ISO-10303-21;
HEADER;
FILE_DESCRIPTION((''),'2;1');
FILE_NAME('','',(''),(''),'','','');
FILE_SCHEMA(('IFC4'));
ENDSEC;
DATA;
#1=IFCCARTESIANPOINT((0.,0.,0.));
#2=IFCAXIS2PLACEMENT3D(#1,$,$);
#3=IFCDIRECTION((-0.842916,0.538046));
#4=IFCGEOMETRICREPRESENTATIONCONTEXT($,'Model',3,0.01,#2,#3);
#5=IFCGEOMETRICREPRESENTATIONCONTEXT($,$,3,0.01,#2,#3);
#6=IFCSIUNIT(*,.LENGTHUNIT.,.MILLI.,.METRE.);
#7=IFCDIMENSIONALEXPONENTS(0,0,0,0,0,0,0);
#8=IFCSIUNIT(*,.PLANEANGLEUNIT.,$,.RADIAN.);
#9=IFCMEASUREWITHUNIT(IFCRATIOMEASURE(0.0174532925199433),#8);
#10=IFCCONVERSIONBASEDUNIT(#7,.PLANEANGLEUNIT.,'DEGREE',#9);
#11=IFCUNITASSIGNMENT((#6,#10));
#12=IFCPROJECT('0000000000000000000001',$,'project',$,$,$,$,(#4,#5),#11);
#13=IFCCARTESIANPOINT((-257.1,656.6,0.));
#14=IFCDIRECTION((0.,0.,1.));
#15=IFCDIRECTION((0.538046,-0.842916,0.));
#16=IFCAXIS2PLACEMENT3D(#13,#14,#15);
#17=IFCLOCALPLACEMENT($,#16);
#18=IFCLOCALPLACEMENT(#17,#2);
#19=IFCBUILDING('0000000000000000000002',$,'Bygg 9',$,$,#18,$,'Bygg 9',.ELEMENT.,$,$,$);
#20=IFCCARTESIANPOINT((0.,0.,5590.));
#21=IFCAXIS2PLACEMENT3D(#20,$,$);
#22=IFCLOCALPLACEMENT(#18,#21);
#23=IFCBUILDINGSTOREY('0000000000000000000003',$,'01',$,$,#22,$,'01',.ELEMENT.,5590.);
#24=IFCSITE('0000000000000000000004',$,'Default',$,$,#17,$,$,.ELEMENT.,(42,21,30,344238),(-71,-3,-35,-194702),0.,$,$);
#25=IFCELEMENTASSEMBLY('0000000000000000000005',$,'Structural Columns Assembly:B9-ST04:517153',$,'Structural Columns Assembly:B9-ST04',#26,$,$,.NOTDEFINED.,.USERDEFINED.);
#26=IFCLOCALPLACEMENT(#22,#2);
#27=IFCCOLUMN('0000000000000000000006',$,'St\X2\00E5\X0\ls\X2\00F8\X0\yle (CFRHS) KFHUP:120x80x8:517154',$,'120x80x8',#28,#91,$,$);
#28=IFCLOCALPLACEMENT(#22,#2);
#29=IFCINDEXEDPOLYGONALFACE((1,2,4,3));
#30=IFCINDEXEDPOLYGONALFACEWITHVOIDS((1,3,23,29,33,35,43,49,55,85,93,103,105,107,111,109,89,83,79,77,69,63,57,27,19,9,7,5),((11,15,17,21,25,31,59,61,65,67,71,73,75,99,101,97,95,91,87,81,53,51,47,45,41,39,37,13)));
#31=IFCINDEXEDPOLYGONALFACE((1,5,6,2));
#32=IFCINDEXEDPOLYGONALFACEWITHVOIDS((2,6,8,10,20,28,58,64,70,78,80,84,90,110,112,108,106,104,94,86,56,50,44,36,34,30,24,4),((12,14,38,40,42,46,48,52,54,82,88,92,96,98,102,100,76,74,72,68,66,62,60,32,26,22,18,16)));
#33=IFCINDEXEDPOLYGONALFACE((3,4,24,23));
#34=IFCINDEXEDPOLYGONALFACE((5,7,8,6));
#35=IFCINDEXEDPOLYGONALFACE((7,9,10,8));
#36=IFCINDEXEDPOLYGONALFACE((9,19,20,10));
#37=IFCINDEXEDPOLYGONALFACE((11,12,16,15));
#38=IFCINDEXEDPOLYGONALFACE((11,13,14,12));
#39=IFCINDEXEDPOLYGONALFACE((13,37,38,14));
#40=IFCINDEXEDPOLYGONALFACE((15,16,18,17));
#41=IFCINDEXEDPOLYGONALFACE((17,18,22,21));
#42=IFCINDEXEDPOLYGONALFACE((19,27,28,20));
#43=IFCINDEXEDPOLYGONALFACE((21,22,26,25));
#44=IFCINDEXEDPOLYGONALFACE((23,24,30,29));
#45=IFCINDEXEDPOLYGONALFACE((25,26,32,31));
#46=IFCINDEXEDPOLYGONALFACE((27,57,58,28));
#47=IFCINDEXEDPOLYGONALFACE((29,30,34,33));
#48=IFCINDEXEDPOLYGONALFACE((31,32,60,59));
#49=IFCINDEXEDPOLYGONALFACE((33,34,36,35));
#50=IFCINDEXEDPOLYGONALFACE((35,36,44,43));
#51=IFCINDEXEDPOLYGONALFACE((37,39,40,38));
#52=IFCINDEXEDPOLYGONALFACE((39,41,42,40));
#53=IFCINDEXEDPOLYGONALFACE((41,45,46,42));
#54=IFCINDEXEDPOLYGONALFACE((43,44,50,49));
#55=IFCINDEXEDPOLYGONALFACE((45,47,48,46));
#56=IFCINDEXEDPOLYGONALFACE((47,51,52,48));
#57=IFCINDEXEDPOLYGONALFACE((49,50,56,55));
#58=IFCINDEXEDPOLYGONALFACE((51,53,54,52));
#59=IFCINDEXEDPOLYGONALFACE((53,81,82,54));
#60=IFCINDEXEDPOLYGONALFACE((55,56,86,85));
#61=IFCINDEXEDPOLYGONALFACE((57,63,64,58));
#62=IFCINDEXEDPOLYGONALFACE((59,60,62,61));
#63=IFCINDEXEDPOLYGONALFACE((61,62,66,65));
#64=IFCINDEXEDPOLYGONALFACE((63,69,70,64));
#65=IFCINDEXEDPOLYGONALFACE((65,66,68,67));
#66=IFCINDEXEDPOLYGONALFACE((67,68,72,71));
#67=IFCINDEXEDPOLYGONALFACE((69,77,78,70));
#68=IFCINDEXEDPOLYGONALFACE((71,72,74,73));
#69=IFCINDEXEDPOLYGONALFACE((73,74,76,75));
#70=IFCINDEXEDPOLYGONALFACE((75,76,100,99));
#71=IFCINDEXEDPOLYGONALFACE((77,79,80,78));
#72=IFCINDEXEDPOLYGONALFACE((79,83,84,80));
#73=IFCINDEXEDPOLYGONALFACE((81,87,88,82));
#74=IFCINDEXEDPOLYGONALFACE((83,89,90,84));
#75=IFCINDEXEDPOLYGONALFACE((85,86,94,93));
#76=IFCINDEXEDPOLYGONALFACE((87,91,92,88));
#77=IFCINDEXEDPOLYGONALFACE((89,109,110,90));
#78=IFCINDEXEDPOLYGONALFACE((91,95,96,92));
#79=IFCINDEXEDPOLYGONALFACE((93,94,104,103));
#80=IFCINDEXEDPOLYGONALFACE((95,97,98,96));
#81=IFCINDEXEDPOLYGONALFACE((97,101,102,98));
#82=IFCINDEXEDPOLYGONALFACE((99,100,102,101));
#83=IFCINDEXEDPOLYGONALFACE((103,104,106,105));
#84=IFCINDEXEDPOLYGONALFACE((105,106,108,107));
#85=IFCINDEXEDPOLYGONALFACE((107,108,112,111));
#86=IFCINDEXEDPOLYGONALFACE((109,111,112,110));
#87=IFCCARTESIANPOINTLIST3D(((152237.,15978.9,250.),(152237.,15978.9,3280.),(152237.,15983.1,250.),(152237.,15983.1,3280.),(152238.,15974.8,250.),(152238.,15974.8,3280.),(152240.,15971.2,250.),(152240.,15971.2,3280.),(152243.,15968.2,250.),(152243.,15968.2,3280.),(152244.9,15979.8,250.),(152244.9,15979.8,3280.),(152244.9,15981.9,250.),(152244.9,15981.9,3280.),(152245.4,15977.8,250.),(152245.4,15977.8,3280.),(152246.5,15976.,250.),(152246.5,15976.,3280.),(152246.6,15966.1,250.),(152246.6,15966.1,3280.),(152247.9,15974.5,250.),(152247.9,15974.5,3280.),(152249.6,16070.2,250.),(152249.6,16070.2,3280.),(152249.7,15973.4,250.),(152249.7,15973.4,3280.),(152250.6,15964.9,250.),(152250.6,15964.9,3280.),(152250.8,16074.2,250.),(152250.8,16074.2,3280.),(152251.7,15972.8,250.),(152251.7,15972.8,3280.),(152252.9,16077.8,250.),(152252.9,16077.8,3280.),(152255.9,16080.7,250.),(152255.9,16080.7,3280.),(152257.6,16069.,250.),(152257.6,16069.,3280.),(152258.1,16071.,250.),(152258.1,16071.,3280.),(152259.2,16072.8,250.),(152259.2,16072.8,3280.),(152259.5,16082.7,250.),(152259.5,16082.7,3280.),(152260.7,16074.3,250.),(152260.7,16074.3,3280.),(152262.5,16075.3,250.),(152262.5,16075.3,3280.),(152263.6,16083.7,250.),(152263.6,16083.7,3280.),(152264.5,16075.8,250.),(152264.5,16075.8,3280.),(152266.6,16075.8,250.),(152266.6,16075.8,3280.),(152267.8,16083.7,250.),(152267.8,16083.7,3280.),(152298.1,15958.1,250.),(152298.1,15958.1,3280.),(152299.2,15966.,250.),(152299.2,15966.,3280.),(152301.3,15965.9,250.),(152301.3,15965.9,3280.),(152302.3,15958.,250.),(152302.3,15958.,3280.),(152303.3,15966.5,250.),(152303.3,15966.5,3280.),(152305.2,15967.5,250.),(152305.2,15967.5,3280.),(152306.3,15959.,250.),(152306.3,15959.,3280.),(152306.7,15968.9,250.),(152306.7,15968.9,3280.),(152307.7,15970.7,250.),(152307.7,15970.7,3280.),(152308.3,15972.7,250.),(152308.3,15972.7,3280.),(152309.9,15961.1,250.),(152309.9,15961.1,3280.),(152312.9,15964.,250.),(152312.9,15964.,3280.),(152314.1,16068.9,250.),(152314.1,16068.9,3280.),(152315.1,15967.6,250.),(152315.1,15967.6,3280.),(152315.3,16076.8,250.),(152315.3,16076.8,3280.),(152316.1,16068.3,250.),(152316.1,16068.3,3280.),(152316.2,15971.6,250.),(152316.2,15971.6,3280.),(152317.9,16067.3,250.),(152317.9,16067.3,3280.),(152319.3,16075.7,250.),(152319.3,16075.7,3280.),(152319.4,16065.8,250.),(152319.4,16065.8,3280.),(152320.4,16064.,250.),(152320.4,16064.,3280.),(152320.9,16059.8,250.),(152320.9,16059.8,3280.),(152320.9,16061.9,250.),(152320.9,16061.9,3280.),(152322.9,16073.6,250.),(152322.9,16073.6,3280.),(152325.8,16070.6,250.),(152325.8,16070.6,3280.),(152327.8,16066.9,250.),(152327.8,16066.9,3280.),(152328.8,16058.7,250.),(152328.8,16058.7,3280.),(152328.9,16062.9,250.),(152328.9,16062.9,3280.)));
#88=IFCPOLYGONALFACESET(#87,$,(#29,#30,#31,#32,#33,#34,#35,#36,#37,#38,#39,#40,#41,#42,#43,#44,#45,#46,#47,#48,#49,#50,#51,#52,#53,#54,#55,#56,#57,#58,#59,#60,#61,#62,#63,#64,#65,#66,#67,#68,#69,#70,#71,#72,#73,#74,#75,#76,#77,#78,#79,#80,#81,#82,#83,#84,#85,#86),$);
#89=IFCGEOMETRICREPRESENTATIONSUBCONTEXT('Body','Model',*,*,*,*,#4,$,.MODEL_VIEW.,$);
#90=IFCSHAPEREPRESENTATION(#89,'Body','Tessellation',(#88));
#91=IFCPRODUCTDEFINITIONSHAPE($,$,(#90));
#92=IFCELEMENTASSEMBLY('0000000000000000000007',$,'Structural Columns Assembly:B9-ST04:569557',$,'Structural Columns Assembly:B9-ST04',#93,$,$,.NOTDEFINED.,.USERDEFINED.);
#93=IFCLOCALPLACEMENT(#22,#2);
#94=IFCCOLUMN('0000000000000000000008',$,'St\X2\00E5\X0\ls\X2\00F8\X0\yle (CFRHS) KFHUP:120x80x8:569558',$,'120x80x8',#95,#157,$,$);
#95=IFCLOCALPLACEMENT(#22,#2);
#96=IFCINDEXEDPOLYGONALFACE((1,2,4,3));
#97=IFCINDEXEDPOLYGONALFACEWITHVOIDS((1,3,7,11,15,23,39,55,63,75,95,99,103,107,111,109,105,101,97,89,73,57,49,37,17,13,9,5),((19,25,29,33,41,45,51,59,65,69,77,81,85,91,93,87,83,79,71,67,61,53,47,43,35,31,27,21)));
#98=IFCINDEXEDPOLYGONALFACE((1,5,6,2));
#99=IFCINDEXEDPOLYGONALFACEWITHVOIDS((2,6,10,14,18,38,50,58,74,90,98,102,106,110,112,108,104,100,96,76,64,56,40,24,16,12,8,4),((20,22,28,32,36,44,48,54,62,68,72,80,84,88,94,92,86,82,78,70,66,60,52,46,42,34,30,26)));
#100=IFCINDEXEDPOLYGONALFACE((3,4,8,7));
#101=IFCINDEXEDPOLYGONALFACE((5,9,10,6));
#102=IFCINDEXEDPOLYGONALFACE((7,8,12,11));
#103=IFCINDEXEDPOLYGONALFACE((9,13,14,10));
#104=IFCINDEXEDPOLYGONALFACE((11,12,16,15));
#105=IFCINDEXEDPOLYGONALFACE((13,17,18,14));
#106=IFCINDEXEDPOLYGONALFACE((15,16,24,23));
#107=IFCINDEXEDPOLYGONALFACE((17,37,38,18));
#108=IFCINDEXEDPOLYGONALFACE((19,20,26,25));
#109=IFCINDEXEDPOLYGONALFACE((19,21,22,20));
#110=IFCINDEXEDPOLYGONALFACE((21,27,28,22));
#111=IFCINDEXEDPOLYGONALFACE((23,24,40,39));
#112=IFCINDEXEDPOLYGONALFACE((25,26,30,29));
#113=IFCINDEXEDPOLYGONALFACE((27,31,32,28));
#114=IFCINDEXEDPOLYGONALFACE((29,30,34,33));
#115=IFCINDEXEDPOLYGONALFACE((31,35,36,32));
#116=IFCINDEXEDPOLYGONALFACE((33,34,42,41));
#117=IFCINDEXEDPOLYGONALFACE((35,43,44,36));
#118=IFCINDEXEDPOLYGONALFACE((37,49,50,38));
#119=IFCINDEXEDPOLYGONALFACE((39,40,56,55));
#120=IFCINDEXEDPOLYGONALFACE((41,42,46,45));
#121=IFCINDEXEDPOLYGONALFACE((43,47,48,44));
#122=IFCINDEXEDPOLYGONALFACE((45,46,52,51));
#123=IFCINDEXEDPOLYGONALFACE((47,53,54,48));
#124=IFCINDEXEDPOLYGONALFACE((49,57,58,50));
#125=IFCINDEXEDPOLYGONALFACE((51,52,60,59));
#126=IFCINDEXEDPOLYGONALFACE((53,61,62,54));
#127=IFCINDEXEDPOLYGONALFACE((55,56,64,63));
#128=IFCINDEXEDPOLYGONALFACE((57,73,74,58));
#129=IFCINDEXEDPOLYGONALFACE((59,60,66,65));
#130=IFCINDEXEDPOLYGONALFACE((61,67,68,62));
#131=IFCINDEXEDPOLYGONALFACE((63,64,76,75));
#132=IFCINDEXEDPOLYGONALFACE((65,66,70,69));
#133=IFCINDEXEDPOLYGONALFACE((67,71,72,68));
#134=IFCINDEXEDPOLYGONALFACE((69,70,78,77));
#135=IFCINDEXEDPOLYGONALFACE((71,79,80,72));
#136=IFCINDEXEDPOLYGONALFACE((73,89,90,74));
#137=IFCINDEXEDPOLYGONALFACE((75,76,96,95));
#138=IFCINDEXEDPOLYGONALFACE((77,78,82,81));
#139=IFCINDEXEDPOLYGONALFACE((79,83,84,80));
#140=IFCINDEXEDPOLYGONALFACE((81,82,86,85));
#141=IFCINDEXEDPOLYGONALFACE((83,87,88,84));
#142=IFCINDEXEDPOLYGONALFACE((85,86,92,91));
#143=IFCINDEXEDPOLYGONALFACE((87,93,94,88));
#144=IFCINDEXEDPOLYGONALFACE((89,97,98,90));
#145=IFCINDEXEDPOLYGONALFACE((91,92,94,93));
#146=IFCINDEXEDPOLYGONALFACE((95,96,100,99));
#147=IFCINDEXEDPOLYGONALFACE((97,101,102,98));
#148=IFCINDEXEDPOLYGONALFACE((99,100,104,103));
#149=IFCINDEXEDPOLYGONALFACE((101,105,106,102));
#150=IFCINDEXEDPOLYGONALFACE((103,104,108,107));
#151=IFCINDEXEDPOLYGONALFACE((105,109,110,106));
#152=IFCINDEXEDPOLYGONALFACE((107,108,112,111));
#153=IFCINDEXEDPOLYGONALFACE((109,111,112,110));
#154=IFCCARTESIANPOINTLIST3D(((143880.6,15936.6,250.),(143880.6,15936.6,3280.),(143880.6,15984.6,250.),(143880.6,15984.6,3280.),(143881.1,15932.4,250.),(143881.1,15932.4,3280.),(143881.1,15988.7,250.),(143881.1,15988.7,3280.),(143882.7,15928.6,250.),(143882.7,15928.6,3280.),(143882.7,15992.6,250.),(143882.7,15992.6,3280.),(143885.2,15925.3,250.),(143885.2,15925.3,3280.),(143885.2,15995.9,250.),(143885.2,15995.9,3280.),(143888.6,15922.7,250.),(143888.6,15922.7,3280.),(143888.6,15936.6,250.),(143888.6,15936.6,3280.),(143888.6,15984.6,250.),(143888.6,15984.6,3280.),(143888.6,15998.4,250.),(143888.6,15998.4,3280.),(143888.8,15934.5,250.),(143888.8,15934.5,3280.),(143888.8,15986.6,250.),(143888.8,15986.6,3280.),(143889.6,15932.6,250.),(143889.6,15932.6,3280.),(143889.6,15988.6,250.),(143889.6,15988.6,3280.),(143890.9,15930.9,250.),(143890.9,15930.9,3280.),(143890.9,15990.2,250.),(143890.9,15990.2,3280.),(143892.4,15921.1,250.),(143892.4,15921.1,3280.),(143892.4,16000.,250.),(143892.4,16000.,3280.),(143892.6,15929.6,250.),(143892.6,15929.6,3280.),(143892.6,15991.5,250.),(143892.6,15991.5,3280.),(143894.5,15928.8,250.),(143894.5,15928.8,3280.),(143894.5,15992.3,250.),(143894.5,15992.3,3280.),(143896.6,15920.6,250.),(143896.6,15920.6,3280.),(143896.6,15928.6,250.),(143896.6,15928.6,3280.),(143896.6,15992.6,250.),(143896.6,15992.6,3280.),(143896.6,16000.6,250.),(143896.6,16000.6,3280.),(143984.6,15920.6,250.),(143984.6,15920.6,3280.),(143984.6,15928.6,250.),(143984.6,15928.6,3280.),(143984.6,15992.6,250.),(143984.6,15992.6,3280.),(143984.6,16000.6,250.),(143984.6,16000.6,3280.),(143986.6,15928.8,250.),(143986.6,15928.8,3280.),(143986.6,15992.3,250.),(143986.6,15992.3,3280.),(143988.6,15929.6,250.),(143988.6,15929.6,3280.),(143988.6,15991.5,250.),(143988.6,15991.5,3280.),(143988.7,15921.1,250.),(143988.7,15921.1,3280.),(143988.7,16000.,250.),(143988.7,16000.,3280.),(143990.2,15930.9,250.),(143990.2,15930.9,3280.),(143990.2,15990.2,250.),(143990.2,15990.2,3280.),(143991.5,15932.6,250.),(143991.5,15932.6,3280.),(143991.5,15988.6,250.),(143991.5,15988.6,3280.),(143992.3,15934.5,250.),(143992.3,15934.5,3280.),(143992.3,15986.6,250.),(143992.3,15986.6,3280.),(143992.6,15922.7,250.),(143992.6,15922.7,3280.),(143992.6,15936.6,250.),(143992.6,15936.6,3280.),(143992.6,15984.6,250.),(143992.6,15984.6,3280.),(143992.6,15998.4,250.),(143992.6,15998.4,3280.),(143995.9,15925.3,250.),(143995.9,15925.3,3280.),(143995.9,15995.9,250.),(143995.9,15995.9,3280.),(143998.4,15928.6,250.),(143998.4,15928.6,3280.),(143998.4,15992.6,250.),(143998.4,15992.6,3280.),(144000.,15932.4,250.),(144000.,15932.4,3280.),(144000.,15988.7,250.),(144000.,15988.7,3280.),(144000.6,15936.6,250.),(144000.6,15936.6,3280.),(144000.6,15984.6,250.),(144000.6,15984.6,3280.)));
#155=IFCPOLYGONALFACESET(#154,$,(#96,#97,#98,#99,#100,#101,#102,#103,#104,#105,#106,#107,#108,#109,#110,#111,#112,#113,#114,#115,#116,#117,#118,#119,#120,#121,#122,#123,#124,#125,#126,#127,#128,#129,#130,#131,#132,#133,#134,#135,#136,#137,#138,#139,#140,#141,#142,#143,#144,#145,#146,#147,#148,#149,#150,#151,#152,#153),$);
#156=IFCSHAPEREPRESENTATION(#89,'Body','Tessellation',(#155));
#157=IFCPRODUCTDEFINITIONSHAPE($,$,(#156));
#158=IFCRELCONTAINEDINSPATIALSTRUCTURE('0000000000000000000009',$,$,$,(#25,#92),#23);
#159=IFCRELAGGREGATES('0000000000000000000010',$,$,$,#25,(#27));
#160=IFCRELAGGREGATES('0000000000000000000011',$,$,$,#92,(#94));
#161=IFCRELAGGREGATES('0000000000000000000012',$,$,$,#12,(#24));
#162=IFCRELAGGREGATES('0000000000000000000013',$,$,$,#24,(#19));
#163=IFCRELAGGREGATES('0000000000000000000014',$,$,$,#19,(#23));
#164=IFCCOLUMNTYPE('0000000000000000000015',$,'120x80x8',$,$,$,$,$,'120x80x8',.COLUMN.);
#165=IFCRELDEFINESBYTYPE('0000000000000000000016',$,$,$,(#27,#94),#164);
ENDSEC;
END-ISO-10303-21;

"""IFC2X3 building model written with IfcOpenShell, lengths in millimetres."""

from ifc_helpers import new_model, entity, si_unit, converted_unit, direction, frame, frame_2d, origin, place, context, subcontext, project, spatial, polyline, circle_curve, parameter, trimmed, segment, composite_curve, outline, extrude, source, transform, mapped, type_object, type_shapes, element, aggregate, save


model = new_model("IFC2X3")

# Units and contexts
model_context = context("Model", 3, precision=0.01, world=origin(), true_north=direction((-0.842916, 0.538046)))
context_of_model = context(None, 3, precision=0.01, world=origin(), true_north=direction((-0.842916, 0.538046)))
body_context = subcontext(model_context, "Body", "Model", "MODEL_VIEW")
ifc_project = project(units=[si_unit("LENGTHUNIT", "METRE", prefix="MILLI"), converted_unit("PLANEANGLEUNIT", "DEGREE", entity("IfcRatioMeasure", 0.0174532925199433), si_unit("PLANEANGLEUNIT", "RADIAN"), dimensions=[0, 0, 0, 0, 0, 0, 0])], contexts=[model_context, context_of_model])

# Site, building, storey
site_placement = place(None, frame((-257.1, 656.6, 0.0), z_axis=(0.0, 0.0, 1.0), x_axis=(0.538046, -0.842916, 0.0)))
site = spatial("IfcSite", under=ifc_project, at=site_placement, Name="Default", CompositionType="ELEMENT", RefLatitude=(42, 21, 30, 344238), RefLongitude=(-71, -3, -35, -194702), RefElevation=0.0)
building_placement = place(site_placement, origin())
building = spatial("IfcBuilding", under=site, at=building_placement, Name="Bygg 9", LongName="Bygg 9", CompositionType="ELEMENT")
storey_placement = place(building_placement, frame((0.0, 0.0, 5590.0)))
storey = spatial("IfcBuildingStorey", under=building, at=storey_placement, Name="01", LongName="01", CompositionType="ELEMENT", Elevation=5590.0)

# Element assemblies, columns
column_type_1 = type_object("IfcColumnType", Name="120x80x8", ElementType="120x80x8", PredefinedType="COLUMN")
shared_shape_1 = source(origin(), body_context, "Body", "SweptSolid", [
    extrude(outline(composite_curve([segment(trimmed(circle_curve(frame_2d((-24.0, 44.0), x_axis=(1.0, 0.0)), 16.0), [parameter(90.0)], [parameter(180.0)], True, "PARAMETER"), True, "CONTINUOUS"), segment(polyline([(-40.0, 44.0), (-40.0, -44.0)]), True, "CONTINUOUS"), segment(trimmed(circle_curve(frame_2d((-24.0, -44.0), x_axis=(1.0, 0.0)), 16.0), [parameter(180.0)], [parameter(270.0)], True, "PARAMETER"), True, "CONTINUOUS"), segment(polyline([(-24.0, -60.0), (24.0, -60.0)]), True, "CONTINUOUS"), segment(trimmed(circle_curve(frame_2d((24.0, -44.0), x_axis=(1.0, 0.0)), 16.0), [parameter(270.0)], [parameter(0.0)], True, "PARAMETER"), True, "CONTINUOUS"), segment(polyline([(40.0, -44.0), (40.0, 44.0)]), True, "CONTINUOUS"), segment(trimmed(circle_curve(frame_2d((24.0, 44.0), x_axis=(1.0, 0.0)), 16.0), [parameter(0.0)], [parameter(90.0)], True, "PARAMETER"), True, "CONTINUOUS"), segment(polyline([(24.0, 60.0), (-24.0, 60.0)]), True, "CONTINUOUS")], self_intersect=False), holes=[composite_curve([segment(polyline([(-24.0, 52.0), (24.0, 52.0)]), True, "CONTINUOUS"), segment(trimmed(circle_curve(frame_2d((24.0, 44.0), x_axis=(1.0, 0.0)), 8.0), [parameter(360.0)], [parameter(90.0)], True, "PARAMETER"), False, "CONTINUOUS"), segment(polyline([(32.0, 44.0), (32.0, -44.0)]), True, "CONTINUOUS"), segment(trimmed(circle_curve(frame_2d((24.0, -44.0), x_axis=(1.0, 0.0)), 8.0), [parameter(270.0)], [parameter(360.0)], True, "PARAMETER"), False, "CONTINUOUS"), segment(polyline([(24.0, -52.0), (-24.0, -52.0)]), True, "CONTINUOUS"), segment(trimmed(circle_curve(frame_2d((-24.0, -44.0), x_axis=(1.0, 0.0)), 8.0), [parameter(180.0)], [parameter(270.0)], True, "PARAMETER"), False, "CONTINUOUS"), segment(polyline([(-32.0, -44.0), (-32.0, 44.0)]), True, "CONTINUOUS"), segment(trimmed(circle_curve(frame_2d((-24.0, 44.0), x_axis=(1.0, 0.0)), 8.0), [parameter(90.0)], [parameter(180.0)], True, "PARAMETER"), False, "CONTINUOUS")], self_intersect=False)]), frame((41.6, 61.6, 0.0), z_axis=(0.0, 0.0, 1.0), x_axis=(-1.0, 0.0, 0.0)), (0.0, 0.0, 1.0), 3030.0),
])
type_shapes(column_type_1, [shared_shape_1])
assembly_1_placement = place(storey_placement, origin())
assembly_1 = element("IfcElementAssembly", 1, at=assembly_1_placement, inside=storey, Name="Structural Columns Assembly:B9-ST04:517153", ObjectType="Structural Columns Assembly:B9-ST04", AssemblyPlace="NOTDEFINED", PredefinedType="USERDEFINED")
column_1_placement = place(assembly_1_placement, frame((152332.9, 16075.9, 250.0), z_axis=(0.0, 0.0, 1.0), x_axis=(-0.989691, 0.143216, 0.0)))
column_1 = element("IfcColumn", 2, at=column_1_placement, type_object=column_type_1, Name="Stålsøyle (CFRHS) KFHUP:120x80x8:517154", ObjectType="120x80x8", context=body_context, shape_type="MappedRepresentation", body=[
    mapped(shared_shape_1, transform((0.0, 0.0, 0.0), scale=1.0)),
])
assembly_2_placement = place(storey_placement, origin())
assembly_2 = element("IfcElementAssembly", 3, at=assembly_2_placement, inside=storey, Name="Structural Columns Assembly:B9-ST04:569557", ObjectType="Structural Columns Assembly:B9-ST04", AssemblyPlace="NOTDEFINED", PredefinedType="USERDEFINED")
column_2_placement = place(assembly_2_placement, frame((144002.1, 15919.0, 250.0), z_axis=(0.0, 0.0, 1.0), x_axis=(0.0, 1.0, 0.0)))
column_2 = element("IfcColumn", 4, at=column_2_placement, type_object=column_type_1, Name="Stålsøyle (CFRHS) KFHUP:120x80x8:569558", ObjectType="120x80x8", context=body_context, shape_type="MappedRepresentation", body=[
    mapped(shared_shape_1, transform((0.0, 0.0, 0.0), scale=1.0)),
])

aggregate(assembly_1, [column_1])
aggregate(assembly_2, [column_2])

save(model, "model.ifc")
